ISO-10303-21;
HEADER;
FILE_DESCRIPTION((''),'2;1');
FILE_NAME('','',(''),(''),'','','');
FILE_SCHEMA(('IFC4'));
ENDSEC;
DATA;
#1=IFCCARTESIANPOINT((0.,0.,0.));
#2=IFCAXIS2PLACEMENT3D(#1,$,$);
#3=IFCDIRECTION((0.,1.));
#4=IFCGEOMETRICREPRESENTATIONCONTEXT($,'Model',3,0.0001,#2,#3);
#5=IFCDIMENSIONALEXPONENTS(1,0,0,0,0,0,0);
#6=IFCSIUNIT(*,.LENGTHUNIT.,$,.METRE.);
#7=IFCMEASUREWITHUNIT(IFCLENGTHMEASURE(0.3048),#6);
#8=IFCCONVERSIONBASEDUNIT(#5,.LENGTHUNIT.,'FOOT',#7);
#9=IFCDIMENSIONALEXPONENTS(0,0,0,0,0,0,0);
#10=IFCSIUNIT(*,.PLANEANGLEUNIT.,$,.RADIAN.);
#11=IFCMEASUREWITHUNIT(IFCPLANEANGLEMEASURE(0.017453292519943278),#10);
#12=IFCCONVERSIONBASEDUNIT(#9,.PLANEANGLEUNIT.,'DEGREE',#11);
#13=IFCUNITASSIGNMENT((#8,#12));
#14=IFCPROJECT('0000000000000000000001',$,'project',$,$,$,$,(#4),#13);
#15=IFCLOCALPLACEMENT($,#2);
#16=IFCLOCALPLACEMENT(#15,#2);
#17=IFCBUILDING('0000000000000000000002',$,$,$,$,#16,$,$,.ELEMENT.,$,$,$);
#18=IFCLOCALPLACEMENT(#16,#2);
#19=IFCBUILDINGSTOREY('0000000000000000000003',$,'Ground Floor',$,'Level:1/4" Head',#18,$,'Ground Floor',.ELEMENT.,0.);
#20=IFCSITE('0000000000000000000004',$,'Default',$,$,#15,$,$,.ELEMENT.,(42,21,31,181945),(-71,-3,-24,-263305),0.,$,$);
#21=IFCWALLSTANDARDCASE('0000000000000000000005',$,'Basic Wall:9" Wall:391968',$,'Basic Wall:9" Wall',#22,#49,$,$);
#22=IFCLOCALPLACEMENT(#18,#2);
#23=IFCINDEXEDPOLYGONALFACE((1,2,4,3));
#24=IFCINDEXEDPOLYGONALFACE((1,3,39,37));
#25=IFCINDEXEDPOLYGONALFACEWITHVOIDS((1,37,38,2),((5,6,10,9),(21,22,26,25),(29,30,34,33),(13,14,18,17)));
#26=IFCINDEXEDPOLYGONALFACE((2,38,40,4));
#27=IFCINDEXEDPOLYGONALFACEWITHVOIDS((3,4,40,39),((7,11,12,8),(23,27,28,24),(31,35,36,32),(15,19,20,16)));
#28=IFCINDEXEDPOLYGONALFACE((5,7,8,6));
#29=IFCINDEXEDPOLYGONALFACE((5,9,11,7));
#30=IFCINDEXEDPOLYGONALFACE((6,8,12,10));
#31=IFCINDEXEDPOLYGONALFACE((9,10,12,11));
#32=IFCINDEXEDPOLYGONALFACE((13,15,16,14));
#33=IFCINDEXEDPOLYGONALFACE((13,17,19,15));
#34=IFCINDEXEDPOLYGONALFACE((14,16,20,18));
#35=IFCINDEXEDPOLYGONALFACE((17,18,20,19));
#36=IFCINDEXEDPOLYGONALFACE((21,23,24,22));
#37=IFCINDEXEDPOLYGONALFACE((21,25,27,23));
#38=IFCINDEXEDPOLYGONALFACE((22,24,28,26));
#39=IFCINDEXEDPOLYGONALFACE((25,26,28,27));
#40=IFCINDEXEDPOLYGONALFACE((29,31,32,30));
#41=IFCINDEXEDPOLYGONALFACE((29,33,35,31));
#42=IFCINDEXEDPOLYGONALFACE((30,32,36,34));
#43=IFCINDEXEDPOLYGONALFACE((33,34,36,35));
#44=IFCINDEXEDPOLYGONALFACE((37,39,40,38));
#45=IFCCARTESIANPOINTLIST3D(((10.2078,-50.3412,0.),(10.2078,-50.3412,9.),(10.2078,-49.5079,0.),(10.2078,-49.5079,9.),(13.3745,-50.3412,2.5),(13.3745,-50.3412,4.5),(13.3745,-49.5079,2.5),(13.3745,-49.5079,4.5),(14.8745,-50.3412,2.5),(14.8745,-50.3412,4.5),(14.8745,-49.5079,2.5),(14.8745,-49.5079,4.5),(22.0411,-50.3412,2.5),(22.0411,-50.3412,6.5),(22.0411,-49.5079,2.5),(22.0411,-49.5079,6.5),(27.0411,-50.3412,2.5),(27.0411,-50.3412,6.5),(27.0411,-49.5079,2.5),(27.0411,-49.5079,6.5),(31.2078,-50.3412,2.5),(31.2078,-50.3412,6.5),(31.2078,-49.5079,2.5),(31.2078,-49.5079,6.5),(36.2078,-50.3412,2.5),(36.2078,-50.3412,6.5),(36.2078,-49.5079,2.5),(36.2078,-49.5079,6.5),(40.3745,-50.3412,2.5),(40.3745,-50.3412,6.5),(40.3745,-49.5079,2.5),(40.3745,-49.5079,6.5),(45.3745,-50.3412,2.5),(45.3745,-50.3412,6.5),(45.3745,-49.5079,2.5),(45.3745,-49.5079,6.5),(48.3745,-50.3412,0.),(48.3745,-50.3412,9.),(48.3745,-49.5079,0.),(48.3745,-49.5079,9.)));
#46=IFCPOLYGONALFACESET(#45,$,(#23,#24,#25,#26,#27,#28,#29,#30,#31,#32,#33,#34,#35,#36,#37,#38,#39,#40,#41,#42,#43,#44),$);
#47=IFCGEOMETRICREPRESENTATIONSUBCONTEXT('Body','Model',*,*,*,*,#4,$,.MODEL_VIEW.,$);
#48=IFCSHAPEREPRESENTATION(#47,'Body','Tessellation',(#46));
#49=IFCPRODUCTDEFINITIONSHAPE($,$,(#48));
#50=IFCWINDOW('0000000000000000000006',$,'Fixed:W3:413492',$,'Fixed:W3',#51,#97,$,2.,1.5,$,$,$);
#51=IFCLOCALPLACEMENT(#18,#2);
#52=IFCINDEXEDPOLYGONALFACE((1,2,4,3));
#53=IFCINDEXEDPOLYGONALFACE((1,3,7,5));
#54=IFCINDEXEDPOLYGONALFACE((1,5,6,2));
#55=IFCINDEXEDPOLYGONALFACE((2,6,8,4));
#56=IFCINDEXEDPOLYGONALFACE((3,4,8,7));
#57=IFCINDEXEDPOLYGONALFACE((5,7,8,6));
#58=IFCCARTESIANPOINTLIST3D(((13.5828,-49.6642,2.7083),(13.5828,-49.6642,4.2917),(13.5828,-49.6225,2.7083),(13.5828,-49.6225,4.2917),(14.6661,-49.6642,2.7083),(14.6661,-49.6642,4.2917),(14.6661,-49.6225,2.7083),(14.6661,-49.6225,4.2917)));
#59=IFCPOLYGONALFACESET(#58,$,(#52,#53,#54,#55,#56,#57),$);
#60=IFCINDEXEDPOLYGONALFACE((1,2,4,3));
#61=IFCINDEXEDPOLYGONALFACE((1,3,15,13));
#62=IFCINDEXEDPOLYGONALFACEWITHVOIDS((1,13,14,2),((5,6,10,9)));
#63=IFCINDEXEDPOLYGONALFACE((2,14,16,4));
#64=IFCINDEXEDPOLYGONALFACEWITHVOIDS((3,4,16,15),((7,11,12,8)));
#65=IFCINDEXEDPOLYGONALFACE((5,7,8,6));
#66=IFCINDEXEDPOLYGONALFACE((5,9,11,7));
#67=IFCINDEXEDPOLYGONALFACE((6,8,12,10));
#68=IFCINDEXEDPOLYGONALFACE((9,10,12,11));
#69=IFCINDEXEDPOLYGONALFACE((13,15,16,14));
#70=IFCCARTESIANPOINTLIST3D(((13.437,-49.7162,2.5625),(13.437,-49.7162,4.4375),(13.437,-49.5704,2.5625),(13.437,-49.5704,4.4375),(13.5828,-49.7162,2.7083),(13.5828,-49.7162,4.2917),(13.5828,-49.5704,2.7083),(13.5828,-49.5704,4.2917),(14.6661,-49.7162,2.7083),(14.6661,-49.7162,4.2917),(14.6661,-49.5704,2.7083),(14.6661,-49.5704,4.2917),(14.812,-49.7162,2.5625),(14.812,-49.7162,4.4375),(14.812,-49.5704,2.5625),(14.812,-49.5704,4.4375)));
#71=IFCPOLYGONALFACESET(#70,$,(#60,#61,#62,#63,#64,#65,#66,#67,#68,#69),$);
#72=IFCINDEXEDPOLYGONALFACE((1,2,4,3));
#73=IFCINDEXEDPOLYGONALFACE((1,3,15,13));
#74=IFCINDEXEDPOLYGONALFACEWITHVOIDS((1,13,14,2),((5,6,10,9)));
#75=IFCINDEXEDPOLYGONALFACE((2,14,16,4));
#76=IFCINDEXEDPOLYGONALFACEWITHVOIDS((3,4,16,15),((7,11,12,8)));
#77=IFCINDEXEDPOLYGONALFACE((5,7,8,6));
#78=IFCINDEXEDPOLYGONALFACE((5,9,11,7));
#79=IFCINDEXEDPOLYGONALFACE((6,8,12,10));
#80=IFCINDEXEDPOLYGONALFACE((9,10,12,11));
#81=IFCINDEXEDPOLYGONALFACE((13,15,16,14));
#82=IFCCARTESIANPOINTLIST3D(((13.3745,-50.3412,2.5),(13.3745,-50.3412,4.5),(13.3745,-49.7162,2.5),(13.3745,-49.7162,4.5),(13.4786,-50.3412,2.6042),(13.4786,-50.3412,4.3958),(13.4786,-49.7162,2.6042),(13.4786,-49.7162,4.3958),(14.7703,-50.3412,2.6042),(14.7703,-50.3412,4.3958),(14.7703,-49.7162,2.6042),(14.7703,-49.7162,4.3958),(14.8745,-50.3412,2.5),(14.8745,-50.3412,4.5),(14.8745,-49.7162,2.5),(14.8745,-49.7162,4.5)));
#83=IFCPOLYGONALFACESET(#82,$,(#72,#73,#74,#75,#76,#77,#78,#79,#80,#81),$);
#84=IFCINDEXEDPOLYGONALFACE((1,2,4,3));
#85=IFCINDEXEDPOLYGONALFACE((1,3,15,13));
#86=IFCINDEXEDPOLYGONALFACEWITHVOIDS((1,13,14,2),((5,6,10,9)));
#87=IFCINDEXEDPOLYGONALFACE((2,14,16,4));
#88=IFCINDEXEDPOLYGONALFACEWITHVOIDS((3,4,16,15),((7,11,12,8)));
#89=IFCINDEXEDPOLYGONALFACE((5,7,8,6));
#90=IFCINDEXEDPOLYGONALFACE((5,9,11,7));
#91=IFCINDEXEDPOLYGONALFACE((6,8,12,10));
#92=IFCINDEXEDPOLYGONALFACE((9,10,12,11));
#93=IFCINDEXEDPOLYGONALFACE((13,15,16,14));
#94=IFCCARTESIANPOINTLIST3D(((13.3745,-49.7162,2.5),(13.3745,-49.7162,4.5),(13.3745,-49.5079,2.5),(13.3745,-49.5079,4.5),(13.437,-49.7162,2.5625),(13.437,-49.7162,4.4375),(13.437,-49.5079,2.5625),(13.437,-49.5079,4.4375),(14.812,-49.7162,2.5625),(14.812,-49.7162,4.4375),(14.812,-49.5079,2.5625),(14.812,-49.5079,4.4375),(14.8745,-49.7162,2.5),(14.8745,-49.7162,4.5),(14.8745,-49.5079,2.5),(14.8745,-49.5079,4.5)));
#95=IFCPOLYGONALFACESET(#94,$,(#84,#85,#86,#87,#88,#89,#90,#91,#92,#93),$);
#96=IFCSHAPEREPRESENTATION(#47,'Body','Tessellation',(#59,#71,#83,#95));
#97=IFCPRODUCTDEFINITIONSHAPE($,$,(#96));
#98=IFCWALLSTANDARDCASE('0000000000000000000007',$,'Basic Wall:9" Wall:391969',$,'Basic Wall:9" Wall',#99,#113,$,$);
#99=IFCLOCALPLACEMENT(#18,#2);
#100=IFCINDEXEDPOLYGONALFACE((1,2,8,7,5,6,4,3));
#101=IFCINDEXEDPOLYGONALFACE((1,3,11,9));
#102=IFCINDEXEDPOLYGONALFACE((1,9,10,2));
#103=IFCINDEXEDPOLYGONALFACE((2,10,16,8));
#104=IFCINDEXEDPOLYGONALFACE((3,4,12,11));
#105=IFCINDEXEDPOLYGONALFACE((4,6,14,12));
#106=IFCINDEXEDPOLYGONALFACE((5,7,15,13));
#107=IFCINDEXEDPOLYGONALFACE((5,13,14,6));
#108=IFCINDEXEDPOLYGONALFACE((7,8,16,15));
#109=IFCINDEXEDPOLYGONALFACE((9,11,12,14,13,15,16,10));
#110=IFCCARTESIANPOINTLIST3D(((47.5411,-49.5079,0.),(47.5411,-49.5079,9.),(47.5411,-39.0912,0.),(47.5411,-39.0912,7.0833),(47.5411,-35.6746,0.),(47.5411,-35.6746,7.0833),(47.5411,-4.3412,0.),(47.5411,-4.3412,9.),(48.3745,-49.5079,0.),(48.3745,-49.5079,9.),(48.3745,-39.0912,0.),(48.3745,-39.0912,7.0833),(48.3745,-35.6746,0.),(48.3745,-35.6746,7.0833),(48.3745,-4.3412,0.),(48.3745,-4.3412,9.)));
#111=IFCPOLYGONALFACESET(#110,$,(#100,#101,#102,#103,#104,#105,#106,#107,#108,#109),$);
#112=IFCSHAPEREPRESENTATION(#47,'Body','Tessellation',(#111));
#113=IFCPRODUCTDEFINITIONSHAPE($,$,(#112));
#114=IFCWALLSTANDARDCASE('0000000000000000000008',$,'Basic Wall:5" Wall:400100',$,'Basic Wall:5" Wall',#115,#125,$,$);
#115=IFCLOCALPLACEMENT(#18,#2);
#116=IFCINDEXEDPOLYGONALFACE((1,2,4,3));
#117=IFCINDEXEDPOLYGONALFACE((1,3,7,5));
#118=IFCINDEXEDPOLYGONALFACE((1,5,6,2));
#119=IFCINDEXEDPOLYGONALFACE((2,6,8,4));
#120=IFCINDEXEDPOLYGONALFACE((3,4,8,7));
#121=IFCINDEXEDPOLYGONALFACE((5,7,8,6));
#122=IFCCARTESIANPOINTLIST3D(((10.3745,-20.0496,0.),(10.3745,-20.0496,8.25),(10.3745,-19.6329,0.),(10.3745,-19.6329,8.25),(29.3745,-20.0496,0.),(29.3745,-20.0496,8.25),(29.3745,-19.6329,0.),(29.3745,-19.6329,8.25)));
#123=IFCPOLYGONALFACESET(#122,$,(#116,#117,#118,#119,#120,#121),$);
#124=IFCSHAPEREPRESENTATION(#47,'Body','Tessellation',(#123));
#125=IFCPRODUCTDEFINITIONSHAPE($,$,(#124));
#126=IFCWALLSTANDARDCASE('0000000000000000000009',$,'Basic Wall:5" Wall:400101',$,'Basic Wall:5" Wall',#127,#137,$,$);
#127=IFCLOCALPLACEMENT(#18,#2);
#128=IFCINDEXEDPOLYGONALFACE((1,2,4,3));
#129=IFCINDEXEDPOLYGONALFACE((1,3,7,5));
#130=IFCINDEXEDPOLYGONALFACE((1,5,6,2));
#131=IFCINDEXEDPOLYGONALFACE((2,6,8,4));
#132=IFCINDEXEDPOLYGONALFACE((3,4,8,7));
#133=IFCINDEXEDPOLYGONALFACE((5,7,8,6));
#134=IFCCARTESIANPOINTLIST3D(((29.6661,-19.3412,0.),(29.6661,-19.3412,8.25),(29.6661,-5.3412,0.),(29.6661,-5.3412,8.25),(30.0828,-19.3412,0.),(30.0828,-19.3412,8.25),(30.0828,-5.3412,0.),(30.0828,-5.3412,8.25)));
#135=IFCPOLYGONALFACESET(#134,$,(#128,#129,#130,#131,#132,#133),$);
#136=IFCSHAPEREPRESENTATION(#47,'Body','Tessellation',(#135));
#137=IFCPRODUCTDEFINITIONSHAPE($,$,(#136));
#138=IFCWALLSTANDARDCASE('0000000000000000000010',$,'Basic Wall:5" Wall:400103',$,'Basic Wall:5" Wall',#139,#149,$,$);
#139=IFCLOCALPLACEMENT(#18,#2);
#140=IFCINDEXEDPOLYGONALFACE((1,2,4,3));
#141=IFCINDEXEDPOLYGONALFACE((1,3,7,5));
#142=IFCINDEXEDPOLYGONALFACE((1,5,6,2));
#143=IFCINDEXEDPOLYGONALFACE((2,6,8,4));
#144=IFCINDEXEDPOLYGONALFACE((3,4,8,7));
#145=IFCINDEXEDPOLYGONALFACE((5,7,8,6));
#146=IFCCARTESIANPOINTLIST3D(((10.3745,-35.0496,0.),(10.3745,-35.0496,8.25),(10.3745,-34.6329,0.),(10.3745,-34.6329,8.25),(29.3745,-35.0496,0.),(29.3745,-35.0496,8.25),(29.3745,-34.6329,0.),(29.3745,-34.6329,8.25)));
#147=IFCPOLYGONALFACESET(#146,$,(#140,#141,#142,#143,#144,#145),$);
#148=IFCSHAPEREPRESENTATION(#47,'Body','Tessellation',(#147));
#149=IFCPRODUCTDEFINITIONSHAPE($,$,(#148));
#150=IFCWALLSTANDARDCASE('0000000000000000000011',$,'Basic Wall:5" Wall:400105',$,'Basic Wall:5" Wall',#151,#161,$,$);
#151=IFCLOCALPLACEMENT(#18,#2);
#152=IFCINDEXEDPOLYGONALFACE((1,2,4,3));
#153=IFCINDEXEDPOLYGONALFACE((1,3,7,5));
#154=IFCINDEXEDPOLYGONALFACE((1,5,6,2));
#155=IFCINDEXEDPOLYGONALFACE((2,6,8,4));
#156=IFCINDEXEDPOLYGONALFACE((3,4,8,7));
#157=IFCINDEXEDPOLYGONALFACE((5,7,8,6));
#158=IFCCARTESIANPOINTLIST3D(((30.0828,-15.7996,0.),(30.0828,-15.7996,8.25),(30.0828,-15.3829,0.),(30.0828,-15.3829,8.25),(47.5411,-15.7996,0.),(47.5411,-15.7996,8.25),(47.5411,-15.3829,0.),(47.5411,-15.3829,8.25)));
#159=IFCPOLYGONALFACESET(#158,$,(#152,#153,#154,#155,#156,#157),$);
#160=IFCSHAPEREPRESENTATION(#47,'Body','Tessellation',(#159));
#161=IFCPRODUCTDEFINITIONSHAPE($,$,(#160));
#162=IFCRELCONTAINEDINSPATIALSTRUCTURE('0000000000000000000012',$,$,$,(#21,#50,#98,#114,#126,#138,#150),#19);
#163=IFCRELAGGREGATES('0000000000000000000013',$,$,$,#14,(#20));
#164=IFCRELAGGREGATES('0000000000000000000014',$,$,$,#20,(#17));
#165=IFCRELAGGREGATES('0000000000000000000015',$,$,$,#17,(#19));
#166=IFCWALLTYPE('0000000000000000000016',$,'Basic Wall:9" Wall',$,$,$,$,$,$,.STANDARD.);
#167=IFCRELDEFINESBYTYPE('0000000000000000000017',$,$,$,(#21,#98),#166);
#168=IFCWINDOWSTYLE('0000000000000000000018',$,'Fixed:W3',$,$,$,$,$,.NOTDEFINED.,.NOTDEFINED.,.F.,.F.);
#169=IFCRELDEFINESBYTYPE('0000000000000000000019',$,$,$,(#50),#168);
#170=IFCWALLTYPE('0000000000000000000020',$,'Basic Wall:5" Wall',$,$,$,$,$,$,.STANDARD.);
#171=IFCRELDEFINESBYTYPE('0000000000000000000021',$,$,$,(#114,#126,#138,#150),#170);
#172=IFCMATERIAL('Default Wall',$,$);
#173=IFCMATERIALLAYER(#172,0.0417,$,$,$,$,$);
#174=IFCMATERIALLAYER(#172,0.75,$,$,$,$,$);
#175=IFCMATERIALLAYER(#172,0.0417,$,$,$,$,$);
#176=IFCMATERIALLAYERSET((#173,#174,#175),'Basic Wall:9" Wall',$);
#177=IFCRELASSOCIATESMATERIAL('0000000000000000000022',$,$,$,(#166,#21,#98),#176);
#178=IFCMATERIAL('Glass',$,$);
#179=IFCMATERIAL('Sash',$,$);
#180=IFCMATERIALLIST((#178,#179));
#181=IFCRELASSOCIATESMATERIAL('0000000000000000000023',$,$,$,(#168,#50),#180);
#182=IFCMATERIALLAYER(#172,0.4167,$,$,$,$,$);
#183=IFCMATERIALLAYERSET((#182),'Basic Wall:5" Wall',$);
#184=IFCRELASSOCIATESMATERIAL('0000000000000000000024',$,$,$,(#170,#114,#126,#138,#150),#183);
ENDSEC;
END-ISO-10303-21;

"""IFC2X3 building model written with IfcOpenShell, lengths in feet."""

from ifc_helpers import new_model, entity, si_unit, converted_unit, direction, frame, frame_2d, origin, origin_2d_with_axis, place, context, subcontext, project, spatial, polyline, rectangle, outline, extrude, clip, bounded_halfspace, source, transform, mapped, material, material_list, layer, layer_set, layer_usage, type_object, type_shapes, element, fill, save


model = new_model("IFC2X3")

# Units and contexts
model_context = context("Model", 3, precision=0.0001, world=origin(), true_north=direction((0.0, 1.0)))
body_context = subcontext(model_context, "Body", "Model", "MODEL_VIEW")
ifc_project = project(units=[converted_unit("LENGTHUNIT", "FOOT", entity("IfcLengthMeasure", 0.3048), si_unit("LENGTHUNIT", "METRE"), dimensions=[1, 0, 0, 0, 0, 0, 0]), converted_unit("PLANEANGLEUNIT", "DEGREE", entity("IfcPlaneAngleMeasure", 0.017453292519943278), si_unit("PLANEANGLEUNIT", "RADIAN"), dimensions=[0, 0, 0, 0, 0, 0, 0])], contexts=[model_context])

# Site, building, storey
site_placement = place(None, origin())
site = spatial("IfcSite", under=ifc_project, at=site_placement, Name="Default", CompositionType="ELEMENT", RefLatitude=(42, 21, 31, 181945), RefLongitude=(-71, -3, -24, -263305), RefElevation=0.0)
building_placement = place(site_placement, origin())
building = spatial("IfcBuilding", under=site, at=building_placement, CompositionType="ELEMENT")
storey_placement = place(building_placement, origin())
storey = spatial("IfcBuildingStorey", under=building, at=storey_placement, Name="Ground Floor", ObjectType="Level:1/4\" Head", LongName="Ground Floor", CompositionType="ELEMENT", Elevation=0.0)

# Shared definitions
ifc_material_1 = material(Name="Default Wall")
ifc_layer_1 = layer(ifc_material_1, 0.0417)
ifc_layer_2 = layer(ifc_material_1, 0.75)
ifc_layer_3 = layer(ifc_material_1, 0.0417)
ifc_layer_set_1 = layer_set([ifc_layer_1, ifc_layer_2, ifc_layer_3], Name="Basic Wall:9\" Wall")
ifc_layer_usage_1 = layer_usage(ifc_layer_set_1, "AXIS2", "NEGATIVE", 0.4167)
wall_type_1 = type_object("IfcWallType", Name="Basic Wall:9\" Wall", PredefinedType="STANDARD", material=ifc_layer_set_1)

# Shared definitions
ifc_material_2 = material(Name="Glass")
ifc_material_3 = material(Name="Sash")
ifc_material_list_1 = material_list([ifc_material_2, ifc_material_3])

# Wall, openings, window
wall_1_placement = place(storey_placement, frame((48.3745, -49.9246, 0.0), z_axis=(0.0, 0.0, 1.0), x_axis=(-1.0, 0.0, 0.0)))
wall_1 = element("IfcWallStandardCase", 1, at=wall_1_placement, inside=storey, type_object=wall_type_1, material=ifc_layer_usage_1, Name="Basic Wall:9\" Wall:391968", ObjectType="Basic Wall:9\" Wall", context=body_context, shape_type="Clipping", body=[
    clip(extrude(rectangle(XDim=38.1667, YDim=0.8333, at=frame_2d((19.0833, 0.0), x_axis=(-1.0, 0.0))), origin(), (0.0, 0.0, 1.0), 9.0), bounded_halfspace(frame((0.0, -0.4167, 9.0), z_axis=(0.0, 0.0, -1.0), x_axis=(0.0, 1.0, 0.0)), True, frame((0.0, -0.4167, 9.0)), polyline([(0.0, 0.0), (0.8333, 0.0), (38.1667, 0.0), (38.1667, 0.8333), (0.0, 0.8333), (0.0, 0.0)]))),
])
opening_1_placement = place(wall_1_placement, frame((3.0, -0.4167, 2.5)))
element("IfcOpeningElement", 2, at=opening_1_placement, cuts=wall_1, ObjectType="Opening", context=body_context, shape_type="SweptSolid", body=[
    extrude(rectangle(XDim=4.0, YDim=5.0, at=frame_2d((2.0, 2.5), x_axis=(-1.0, 0.0))), frame((0.0, 0.0, 0.0), z_axis=(0.0, 1.0, 0.0), x_axis=(0.0, 0.0, 1.0)), (0.0, 0.0, 1.0), 0.8333),
])
opening_2_placement = place(wall_1_placement, frame((12.1667, -0.4167, 2.5)))
element("IfcOpeningElement", 3, at=opening_2_placement, cuts=wall_1, ObjectType="Opening", context=body_context, shape_type="SweptSolid", body=[
    extrude(rectangle(XDim=4.0, YDim=5.0, at=frame_2d((2.0, 2.5), x_axis=(-1.0, 0.0))), frame((0.0, 0.0, 0.0), z_axis=(0.0, 1.0, 0.0), x_axis=(0.0, 0.0, 1.0)), (0.0, 0.0, 1.0), 0.8333),
])
opening_3_placement = place(wall_1_placement, frame((35.0, 0.4167, 2.5)))
opening_3 = element("IfcOpeningElement", 4, at=opening_3_placement, cuts=wall_1, ObjectType="Opening", context=body_context, shape_type="SweptSolid", body=[
    extrude(rectangle(XDim=2.0, YDim=1.5, at=frame_2d((1.0, 0.75), x_axis=(-1.0, 0.0))), frame((0.0, 0.0, 0.0), z_axis=(0.0, -1.0, 0.0), x_axis=(0.0, 0.0, 1.0)), (0.0, 0.0, 1.0), 0.8333),
])
opening_4_placement = place(wall_1_placement, frame((26.3333, 0.4167, 2.5)))
element("IfcOpeningElement", 5, at=opening_4_placement, cuts=wall_1, ObjectType="Opening", context=body_context, shape_type="SweptSolid", body=[
    extrude(rectangle(XDim=4.0, YDim=5.0, at=frame_2d((2.0, 2.5), x_axis=(-1.0, 0.0))), frame((0.0, 0.0, 0.0), z_axis=(0.0, -1.0, 0.0), x_axis=(0.0, 0.0, 1.0)), (0.0, 0.0, 1.0), 0.8333),
])
window_style_1 = type_object("IfcWindowStyle", Name="Fixed:W3", ConstructionType="NOTDEFINED", OperationType="NOTDEFINED", ParameterTakesPrecedence=False, Sizeable=False, material=ifc_material_list_1)
shared_shape_1 = source(origin(), body_context, "Body", "SweptSolid", [
    extrude(rectangle(XDim=0.0417, YDim=1.0833, at=origin_2d_with_axis()), frame((0.75, 0.6979, 0.2083), z_axis=(0.0, 0.0, 1.0), x_axis=(0.0, 1.0, 0.0)), (0.0, 0.0, 1.0), 1.5833),
    extrude(outline(polyline([(-0.6875, -0.9375), (0.6875, -0.9375), (0.6875, 0.9375), (-0.6875, 0.9375), (-0.6875, -0.9375)]), holes=[polyline([(-0.5417, -0.7917), (-0.5417, 0.7917), (0.5417, 0.7917), (0.5417, -0.7917), (-0.5417, -0.7917)])]), frame((0.75, 0.625, 1.0), z_axis=(0.0, 1.0, 0.0), x_axis=(1.0, 0.0, 0.0)), (0.0, 0.0, 1.0), 0.1458),
    extrude(outline(polyline([(-0.75, -1.0), (0.75, -1.0), (0.75, 1.0), (-0.75, 1.0), (-0.75, -1.0)]), holes=[polyline([(-0.6458, -0.8958), (-0.6458, 0.8958), (0.6458, 0.8958), (0.6458, -0.8958), (-0.6458, -0.8958)])]), frame((0.75, 0.0, 1.0), z_axis=(0.0, 1.0, 0.0), x_axis=(1.0, 0.0, 0.0)), (0.0, 0.0, 1.0), 0.625),
    extrude(outline(polyline([(-1.0, -0.75), (1.0, -0.75), (1.0, 0.75), (-1.0, 0.75), (-1.0, -0.75)]), holes=[polyline([(-0.9375, -0.6875), (-0.9375, 0.6875), (0.9375, 0.6875), (0.9375, -0.6875), (-0.9375, -0.6875)])]), frame((0.75, 0.625, 1.0), z_axis=(0.0, 1.0, 0.0), x_axis=(0.0, 0.0, -1.0)), (0.0, 0.0, 1.0), 0.2083),
])
type_shapes(window_style_1, [shared_shape_1])
window_1_placement = place(opening_3_placement, frame((0.0, 0.0, 0.0), z_axis=(0.0, 0.0, 1.0), x_axis=(-1.0, 0.0, 0.0)))
window_1 = element("IfcWindow", 6, at=window_1_placement, inside=storey, type_object=window_style_1, material=ifc_material_list_1, Name="Fixed:W3:413492", ObjectType="Fixed:W3", OverallHeight=2.0, OverallWidth=1.5, context=body_context, shape_type="MappedRepresentation", body=[
    mapped(shared_shape_1, transform((0.0, 0.0, 0.0), scale=1.0)),
])
fill(opening_3, window_1)

# Wall, opening
wall_2_placement = place(storey_placement, frame((47.9578, -4.3412, 0.0), z_axis=(0.0, 0.0, 1.0), x_axis=(0.0, -1.0, 0.0)))
wall_2 = element("IfcWallStandardCase", 7, at=wall_2_placement, inside=storey, type_object=wall_type_1, material=ifc_layer_usage_1, Name="Basic Wall:9\" Wall:391969", ObjectType="Basic Wall:9\" Wall", context=body_context, shape_type="Clipping", body=[
    clip(extrude(rectangle(XDim=45.1667, YDim=0.8333, at=frame_2d((22.5833, 0.0), x_axis=(1.0, 0.0))), origin(), (0.0, 0.0, 1.0), 9.0), bounded_halfspace(frame((0.0, -0.4167, 9.0), z_axis=(0.0, 0.0, -1.0), x_axis=(1.0, 0.0, 0.0)), True, frame((0.0, -0.4167, 9.0)), polyline([(0.0, 0.0), (45.1667, 0.0), (45.1667, 0.8333), (0.0, 0.8333), (0.0, 0.0)]))),
])
opening_5_placement = place(wall_2_placement, frame((34.75, 0.4167, 0.0)))
element("IfcOpeningElement", 8, at=opening_5_placement, cuts=wall_2, ObjectType="Opening", context=body_context, shape_type="SweptSolid", body=[
    extrude(rectangle(XDim=7.0833, YDim=3.4167, at=frame_2d((3.5417, 1.7083), x_axis=(1.0, 0.0))), frame((0.0, 0.0, 0.0), z_axis=(0.0, -1.0, 0.0), x_axis=(0.0, 0.0, 1.0)), (0.0, 0.0, 1.0), 0.8333),
])

# Walls
ifc_layer_4 = layer(ifc_material_1, 0.4167)
ifc_layer_set_2 = layer_set([ifc_layer_4], Name="Basic Wall:5\" Wall")
ifc_layer_usage_2 = layer_usage(ifc_layer_set_2, "AXIS2", "NEGATIVE", 0.2083)
wall_type_2 = type_object("IfcWallType", Name="Basic Wall:5\" Wall", PredefinedType="STANDARD", material=ifc_layer_set_2)
wall_3_placement = place(storey_placement, frame((10.3745, -19.8412, 0.0)))
element("IfcWallStandardCase", 9, at=wall_3_placement, inside=storey, type_object=wall_type_2, material=ifc_layer_usage_2, Name="Basic Wall:5\" Wall:400100", ObjectType="Basic Wall:5\" Wall", context=body_context, shape_type="SweptSolid", body=[
    extrude(rectangle(XDim=19.0, YDim=0.4167, at=frame_2d((9.5, 0.0), x_axis=(-1.0, 0.0))), origin(), (0.0, 0.0, 1.0), 8.25),
])
wall_4_placement = place(storey_placement, frame((29.8745, -19.3412, 0.0), z_axis=(0.0, 0.0, 1.0), x_axis=(0.0, 1.0, 0.0)))
element("IfcWallStandardCase", 10, at=wall_4_placement, inside=storey, type_object=wall_type_2, material=ifc_layer_usage_2, Name="Basic Wall:5\" Wall:400101", ObjectType="Basic Wall:5\" Wall", context=body_context, shape_type="SweptSolid", body=[
    extrude(rectangle(XDim=14.0, YDim=0.4167, at=frame_2d((7.0, 0.0), x_axis=(-1.0, 0.0))), origin(), (0.0, 0.0, 1.0), 8.25),
])

# Wall
wall_5_placement = place(storey_placement, frame((29.3745, -34.8412, 0.0), z_axis=(0.0, 0.0, 1.0), x_axis=(-1.0, 0.0, 0.0)))
element("IfcWallStandardCase", 11, at=wall_5_placement, inside=storey, type_object=wall_type_2, material=ifc_layer_usage_2, Name="Basic Wall:5\" Wall:400103", ObjectType="Basic Wall:5\" Wall", context=body_context, shape_type="SweptSolid", body=[
    extrude(rectangle(XDim=19.0, YDim=0.4167, at=frame_2d((9.5, 0.0), x_axis=(-1.0, 0.0))), origin(), (0.0, 0.0, 1.0), 8.25),
])

# Wall
wall_6_placement = place(storey_placement, frame((30.0828, -15.5912, 0.0)))
element("IfcWallStandardCase", 12, at=wall_6_placement, inside=storey, type_object=wall_type_2, material=ifc_layer_usage_2, Name="Basic Wall:5\" Wall:400105", ObjectType="Basic Wall:5\" Wall", context=body_context, shape_type="SweptSolid", body=[
    extrude(rectangle(XDim=17.4583, YDim=0.4167, at=frame_2d((8.7292, 0.0), x_axis=(-1.0, 0.0))), origin(), (0.0, 0.0, 1.0), 8.25),
])

save(model, "model.ifc")
